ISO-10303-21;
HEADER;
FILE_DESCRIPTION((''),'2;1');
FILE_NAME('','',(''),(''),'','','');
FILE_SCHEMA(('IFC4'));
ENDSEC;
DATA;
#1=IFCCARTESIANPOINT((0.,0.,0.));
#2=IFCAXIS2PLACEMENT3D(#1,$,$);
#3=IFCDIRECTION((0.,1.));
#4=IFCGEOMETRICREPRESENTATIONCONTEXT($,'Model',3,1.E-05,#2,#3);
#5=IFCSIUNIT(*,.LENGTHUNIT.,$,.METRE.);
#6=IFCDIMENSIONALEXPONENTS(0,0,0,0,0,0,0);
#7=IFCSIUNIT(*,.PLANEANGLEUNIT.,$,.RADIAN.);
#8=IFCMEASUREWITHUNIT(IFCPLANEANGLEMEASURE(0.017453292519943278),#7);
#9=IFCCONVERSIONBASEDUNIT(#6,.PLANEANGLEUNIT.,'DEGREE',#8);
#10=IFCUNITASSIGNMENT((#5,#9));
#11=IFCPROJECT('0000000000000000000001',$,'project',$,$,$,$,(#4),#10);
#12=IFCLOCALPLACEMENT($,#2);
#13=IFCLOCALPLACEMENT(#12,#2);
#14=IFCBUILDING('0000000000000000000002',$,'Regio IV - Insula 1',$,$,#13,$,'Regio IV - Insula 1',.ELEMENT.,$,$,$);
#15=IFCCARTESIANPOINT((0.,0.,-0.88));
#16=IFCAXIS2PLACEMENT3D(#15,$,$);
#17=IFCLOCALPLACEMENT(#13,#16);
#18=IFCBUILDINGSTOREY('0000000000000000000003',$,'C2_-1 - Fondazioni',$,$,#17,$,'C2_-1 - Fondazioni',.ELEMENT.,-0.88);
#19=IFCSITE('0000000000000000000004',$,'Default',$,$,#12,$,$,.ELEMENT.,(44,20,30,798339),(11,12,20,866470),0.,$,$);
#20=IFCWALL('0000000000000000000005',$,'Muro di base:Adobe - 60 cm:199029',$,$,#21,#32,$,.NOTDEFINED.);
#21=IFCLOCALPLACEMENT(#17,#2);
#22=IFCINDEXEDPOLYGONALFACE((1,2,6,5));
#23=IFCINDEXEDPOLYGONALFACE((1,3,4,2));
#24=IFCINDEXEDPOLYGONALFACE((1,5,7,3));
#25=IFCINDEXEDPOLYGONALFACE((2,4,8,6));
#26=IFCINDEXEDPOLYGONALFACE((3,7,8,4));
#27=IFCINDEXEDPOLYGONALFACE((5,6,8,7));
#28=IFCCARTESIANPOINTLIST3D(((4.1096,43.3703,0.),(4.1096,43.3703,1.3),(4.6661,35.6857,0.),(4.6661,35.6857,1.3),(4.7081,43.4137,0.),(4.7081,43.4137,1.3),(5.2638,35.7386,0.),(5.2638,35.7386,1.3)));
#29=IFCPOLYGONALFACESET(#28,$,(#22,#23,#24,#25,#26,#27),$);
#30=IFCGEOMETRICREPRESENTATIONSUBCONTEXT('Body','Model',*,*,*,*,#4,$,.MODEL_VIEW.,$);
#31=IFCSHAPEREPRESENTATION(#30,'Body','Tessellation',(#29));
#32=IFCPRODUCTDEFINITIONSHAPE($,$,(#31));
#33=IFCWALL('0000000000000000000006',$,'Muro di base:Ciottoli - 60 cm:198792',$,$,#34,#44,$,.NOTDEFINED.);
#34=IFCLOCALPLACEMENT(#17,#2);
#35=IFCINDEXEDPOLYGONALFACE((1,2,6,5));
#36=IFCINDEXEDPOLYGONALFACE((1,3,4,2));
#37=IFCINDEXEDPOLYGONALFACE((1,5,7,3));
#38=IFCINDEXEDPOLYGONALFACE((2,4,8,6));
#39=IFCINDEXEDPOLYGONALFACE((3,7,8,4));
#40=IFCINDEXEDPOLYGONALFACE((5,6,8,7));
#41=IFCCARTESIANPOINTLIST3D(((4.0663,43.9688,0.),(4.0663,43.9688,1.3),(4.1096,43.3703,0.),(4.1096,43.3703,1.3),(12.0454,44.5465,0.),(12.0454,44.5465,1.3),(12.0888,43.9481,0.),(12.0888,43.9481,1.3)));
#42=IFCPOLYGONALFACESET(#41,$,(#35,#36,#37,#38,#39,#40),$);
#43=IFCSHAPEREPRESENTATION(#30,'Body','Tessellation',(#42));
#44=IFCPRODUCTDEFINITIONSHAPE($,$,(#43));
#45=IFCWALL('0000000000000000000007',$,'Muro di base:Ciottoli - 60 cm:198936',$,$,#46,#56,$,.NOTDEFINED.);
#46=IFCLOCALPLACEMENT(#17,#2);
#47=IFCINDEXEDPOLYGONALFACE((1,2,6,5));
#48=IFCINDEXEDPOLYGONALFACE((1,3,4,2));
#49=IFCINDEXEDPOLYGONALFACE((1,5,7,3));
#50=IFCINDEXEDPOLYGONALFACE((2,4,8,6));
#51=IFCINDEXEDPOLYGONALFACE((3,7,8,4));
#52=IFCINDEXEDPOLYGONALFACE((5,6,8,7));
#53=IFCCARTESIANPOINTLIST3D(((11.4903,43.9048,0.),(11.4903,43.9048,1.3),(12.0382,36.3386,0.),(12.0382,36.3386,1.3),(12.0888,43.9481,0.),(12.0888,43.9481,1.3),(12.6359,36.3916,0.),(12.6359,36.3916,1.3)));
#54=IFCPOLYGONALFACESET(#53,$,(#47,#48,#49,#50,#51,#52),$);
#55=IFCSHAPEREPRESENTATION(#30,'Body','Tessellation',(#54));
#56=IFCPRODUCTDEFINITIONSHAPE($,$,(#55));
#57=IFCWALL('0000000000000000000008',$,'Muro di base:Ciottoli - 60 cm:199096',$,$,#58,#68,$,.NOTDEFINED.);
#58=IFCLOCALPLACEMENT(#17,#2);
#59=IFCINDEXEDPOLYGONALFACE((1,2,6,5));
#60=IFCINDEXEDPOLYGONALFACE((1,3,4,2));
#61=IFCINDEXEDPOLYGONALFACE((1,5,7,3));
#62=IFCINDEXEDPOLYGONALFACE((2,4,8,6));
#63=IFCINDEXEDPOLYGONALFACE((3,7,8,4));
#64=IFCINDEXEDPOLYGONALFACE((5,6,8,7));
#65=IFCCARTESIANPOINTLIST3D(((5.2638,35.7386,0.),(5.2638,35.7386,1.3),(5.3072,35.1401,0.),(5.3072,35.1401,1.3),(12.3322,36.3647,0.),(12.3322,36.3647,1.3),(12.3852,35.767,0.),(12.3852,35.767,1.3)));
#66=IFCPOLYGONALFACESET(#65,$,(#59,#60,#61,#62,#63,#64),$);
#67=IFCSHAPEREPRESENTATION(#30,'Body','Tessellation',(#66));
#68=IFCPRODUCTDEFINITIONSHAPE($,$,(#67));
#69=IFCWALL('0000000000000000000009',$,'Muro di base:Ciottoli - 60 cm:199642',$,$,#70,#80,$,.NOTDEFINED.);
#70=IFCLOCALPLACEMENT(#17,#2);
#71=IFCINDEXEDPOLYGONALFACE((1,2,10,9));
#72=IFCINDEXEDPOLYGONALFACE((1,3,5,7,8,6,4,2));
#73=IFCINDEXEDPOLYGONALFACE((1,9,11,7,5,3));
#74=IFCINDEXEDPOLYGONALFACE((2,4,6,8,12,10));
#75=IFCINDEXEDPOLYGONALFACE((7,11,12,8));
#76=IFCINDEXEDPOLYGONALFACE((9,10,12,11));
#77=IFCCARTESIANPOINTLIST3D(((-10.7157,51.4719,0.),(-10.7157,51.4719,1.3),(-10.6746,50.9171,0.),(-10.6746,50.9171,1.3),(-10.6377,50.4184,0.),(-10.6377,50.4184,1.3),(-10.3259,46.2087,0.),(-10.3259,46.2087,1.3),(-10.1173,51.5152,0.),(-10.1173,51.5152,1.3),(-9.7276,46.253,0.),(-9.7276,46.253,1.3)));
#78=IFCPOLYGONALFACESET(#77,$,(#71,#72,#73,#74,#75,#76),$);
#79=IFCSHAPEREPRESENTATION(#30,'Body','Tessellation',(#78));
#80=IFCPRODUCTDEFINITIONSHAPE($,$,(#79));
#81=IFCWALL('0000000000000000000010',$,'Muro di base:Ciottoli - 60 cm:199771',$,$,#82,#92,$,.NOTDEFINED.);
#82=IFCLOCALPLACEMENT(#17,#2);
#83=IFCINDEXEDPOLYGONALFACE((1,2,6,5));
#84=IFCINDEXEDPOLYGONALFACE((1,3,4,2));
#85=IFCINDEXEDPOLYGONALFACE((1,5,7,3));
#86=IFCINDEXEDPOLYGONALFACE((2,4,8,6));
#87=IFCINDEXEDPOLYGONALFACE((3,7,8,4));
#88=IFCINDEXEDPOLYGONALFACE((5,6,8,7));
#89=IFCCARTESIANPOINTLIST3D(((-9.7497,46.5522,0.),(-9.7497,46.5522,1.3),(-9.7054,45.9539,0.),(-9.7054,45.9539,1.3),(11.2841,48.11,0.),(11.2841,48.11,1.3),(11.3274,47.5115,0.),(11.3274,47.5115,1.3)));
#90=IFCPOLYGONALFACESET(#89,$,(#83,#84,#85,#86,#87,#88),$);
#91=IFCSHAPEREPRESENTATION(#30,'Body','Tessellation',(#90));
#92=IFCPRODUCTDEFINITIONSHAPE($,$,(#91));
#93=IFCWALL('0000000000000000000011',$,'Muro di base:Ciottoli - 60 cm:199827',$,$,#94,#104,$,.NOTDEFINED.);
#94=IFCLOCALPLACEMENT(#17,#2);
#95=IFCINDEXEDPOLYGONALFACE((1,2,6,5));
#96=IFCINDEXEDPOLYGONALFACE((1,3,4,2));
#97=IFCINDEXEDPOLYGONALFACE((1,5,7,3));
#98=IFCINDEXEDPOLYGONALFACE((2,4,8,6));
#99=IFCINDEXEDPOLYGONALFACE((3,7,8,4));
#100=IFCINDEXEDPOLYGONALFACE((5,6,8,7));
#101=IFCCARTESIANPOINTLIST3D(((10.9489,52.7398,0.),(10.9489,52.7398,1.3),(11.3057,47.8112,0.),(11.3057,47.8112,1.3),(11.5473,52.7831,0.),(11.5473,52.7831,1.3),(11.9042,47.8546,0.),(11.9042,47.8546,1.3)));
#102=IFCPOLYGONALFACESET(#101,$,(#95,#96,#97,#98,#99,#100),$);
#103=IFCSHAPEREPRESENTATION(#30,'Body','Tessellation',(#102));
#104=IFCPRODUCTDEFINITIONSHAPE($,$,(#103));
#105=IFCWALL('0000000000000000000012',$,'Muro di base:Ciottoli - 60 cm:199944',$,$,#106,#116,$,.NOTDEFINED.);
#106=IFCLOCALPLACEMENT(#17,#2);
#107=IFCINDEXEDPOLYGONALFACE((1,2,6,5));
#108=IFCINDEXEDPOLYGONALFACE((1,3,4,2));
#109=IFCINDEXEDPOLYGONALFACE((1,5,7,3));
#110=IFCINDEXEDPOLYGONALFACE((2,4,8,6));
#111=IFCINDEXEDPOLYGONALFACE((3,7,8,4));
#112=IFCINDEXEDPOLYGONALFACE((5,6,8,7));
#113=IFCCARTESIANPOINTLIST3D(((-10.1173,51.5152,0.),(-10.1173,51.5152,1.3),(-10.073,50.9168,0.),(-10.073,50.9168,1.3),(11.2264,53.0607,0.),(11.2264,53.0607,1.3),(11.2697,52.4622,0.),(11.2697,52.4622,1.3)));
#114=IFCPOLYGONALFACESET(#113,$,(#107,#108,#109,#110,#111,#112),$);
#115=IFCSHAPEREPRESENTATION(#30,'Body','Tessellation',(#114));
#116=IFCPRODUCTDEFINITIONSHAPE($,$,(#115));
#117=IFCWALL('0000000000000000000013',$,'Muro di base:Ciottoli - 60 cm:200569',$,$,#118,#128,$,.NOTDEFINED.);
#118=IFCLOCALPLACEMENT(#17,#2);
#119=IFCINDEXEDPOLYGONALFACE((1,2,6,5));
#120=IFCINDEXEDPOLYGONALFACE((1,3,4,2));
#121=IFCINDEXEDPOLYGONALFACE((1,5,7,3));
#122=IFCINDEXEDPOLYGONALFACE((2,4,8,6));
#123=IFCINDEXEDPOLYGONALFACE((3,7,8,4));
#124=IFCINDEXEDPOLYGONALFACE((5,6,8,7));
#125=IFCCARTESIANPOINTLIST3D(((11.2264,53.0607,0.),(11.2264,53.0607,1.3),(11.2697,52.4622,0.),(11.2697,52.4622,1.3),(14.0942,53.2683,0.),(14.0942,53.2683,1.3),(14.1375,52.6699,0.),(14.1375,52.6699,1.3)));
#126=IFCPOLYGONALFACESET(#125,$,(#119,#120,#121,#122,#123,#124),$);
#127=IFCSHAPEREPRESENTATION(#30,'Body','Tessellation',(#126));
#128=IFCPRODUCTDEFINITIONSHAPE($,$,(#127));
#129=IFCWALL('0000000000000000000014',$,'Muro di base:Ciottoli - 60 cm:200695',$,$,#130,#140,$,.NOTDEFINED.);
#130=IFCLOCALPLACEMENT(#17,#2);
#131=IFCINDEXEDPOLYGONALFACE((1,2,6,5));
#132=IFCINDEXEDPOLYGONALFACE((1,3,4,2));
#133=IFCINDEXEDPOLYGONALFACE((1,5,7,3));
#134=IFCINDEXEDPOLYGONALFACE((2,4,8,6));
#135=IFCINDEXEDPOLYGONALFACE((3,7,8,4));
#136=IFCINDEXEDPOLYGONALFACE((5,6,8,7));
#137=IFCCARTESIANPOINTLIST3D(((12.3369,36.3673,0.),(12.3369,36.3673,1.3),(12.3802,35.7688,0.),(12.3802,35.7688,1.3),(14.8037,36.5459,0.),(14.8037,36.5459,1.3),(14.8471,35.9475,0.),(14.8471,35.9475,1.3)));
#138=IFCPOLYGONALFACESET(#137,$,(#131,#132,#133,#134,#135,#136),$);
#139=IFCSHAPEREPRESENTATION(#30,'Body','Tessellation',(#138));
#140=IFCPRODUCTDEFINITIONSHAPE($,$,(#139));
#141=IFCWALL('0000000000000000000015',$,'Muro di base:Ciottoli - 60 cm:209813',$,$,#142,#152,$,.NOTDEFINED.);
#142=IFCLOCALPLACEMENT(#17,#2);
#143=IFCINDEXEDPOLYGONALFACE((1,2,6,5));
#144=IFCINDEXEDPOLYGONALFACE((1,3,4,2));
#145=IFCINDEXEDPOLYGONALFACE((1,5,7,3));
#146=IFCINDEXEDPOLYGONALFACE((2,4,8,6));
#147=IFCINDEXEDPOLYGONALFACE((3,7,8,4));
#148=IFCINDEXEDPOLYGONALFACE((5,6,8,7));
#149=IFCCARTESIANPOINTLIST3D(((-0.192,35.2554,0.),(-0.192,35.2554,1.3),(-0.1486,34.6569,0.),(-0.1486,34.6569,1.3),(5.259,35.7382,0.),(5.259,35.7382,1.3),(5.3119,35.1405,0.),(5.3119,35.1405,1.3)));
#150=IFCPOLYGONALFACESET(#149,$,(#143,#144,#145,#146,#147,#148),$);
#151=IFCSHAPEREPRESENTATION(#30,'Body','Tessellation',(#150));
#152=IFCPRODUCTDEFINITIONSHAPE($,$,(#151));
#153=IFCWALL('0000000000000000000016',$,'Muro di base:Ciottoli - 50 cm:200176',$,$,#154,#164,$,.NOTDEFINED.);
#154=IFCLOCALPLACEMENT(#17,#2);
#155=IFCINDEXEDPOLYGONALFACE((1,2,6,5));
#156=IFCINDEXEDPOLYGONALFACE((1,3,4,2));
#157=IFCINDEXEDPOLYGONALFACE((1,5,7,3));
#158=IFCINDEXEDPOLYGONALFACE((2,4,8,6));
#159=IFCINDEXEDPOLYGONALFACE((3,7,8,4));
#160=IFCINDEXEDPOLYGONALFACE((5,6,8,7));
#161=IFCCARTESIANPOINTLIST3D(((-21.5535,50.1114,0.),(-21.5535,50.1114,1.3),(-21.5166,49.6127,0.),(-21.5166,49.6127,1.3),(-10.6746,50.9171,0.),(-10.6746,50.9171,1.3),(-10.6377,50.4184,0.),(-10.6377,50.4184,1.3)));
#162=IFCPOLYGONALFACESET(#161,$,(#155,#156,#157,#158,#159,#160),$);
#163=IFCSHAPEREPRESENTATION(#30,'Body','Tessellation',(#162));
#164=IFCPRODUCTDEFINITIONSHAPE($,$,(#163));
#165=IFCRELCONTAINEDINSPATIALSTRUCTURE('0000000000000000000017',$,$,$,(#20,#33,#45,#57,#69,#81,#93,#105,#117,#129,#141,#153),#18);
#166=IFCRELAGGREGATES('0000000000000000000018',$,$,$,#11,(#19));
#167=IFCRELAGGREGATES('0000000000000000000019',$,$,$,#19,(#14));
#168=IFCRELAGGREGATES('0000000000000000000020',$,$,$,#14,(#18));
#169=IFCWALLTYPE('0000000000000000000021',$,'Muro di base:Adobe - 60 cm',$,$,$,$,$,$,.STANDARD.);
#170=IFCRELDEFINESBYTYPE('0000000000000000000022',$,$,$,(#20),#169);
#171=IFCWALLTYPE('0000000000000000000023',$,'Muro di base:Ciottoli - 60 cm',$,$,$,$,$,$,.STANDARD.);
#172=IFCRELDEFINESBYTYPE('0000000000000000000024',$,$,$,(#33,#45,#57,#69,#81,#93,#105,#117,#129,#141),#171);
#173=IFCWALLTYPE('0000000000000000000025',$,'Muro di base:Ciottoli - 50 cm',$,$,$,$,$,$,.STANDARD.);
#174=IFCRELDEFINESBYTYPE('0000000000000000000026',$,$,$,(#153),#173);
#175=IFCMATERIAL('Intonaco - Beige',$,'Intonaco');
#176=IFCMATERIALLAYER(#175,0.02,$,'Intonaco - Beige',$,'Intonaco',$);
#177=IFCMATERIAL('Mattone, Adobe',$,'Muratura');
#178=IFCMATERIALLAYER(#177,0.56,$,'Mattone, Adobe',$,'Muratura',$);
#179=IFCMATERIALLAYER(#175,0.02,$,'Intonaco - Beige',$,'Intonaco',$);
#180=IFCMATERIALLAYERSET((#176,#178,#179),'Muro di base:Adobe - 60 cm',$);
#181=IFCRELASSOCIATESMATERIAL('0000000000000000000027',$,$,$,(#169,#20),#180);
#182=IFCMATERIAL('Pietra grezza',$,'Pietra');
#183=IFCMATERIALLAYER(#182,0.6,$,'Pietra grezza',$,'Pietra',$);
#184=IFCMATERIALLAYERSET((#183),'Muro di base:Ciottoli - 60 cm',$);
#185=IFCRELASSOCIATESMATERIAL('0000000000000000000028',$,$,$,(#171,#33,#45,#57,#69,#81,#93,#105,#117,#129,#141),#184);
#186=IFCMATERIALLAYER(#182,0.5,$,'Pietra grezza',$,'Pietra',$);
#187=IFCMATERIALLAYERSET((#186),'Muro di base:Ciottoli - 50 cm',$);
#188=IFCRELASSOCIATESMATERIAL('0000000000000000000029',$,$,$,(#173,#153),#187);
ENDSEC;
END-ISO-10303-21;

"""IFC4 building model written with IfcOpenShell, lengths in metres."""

from ifc_helpers import new_model, entity, si_unit, converted_unit, direction, frame, frame_2d, origin, place, context, subcontext, project, spatial, polyline, rectangle, outline, extrude, material, layer, layer_set, layer_usage, type_object, element, save


model = new_model("IFC4")

# Units and contexts
model_context = context("Model", 3, precision=1e-05, world=origin(), true_north=direction((0.0, 1.0)))
body_context = subcontext(model_context, "Body", "Model", "MODEL_VIEW")
ifc_project = project(units=[si_unit("LENGTHUNIT", "METRE"), converted_unit("PLANEANGLEUNIT", "DEGREE", entity("IfcPlaneAngleMeasure", 0.017453292519943278), si_unit("PLANEANGLEUNIT", "RADIAN"), dimensions=[0, 0, 0, 0, 0, 0, 0])], contexts=[model_context])

# Site, building, storey
site_placement = place(None, origin())
site = spatial("IfcSite", under=ifc_project, at=site_placement, Name="Default", CompositionType="ELEMENT", RefLatitude=(44, 20, 30, 798339), RefLongitude=(11, 12, 20, 866470), RefElevation=0.0)
building_placement = place(site_placement, origin())
building = spatial("IfcBuilding", under=site, at=building_placement, Name="Regio IV - Insula 1", LongName="Regio IV - Insula 1", CompositionType="ELEMENT")
storey_placement = place(building_placement, frame((0.0, 0.0, -0.88)))
storey = spatial("IfcBuildingStorey", under=building, at=storey_placement, Name="C2_-1 - Fondazioni", LongName="C2_-1 - Fondazioni", CompositionType="ELEMENT", Elevation=-0.88)

# Walls
ifc_material_1 = material(Name="Intonaco - Beige", Category="Intonaco")
ifc_layer_1 = layer(ifc_material_1, 0.02, Name="Intonaco - Beige", Category="Intonaco")
ifc_material_2 = material(Name="Mattone, Adobe", Category="Muratura")
ifc_layer_2 = layer(ifc_material_2, 0.56, Name="Mattone, Adobe", Category="Muratura")
ifc_layer_3 = layer(ifc_material_1, 0.02, Name="Intonaco - Beige", Category="Intonaco")
ifc_layer_set_1 = layer_set([ifc_layer_1, ifc_layer_2, ifc_layer_3], Name="Muro di base:Adobe - 60 cm")
ifc_layer_usage_1 = layer_usage(ifc_layer_set_1, "AXIS2", "NEGATIVE", 0.3)
wall_type_1 = type_object("IfcWallType", Name="Muro di base:Adobe - 60 cm", PredefinedType="STANDARD", material=ifc_layer_set_1)
wall_1_placement = place(storey_placement, frame((4.4089, 43.392, 0.0), z_axis=(0.0, 0.0, 1.0), x_axis=(0.07222, -0.997389, 0.0)))
element("IfcWall", 1, at=wall_1_placement, inside=storey, type_object=wall_type_1, material=ifc_layer_usage_1, Name="Muro di base:Adobe - 60 cm:199029", PredefinedType="NOTDEFINED", context=body_context, shape_type="SweptSolid", body=[
    extrude(outline(polyline([(7.7048, -0.3), (7.6951, 0.3), (0.0, 0.3), (0.0, -0.3), (7.7048, -0.3)])), origin(), (0.0, 0.0, 1.0), 1.3),
])
ifc_material_3 = material(Name="Pietra grezza", Category="Pietra")
ifc_layer_4 = layer(ifc_material_3, 0.6, Name="Pietra grezza", Category="Pietra")
ifc_layer_set_2 = layer_set([ifc_layer_4], Name="Muro di base:Ciottoli - 60 cm")
ifc_layer_usage_2 = layer_usage(ifc_layer_set_2, "AXIS2", "NEGATIVE", 0.3)
wall_type_2 = type_object("IfcWallType", Name="Muro di base:Ciottoli - 60 cm", PredefinedType="STANDARD", material=ifc_layer_set_2)
wall_2_placement = place(storey_placement, frame((4.088, 43.6695, 0.0), z_axis=(0.0, 0.0, 1.0), x_axis=(0.997389, 0.07222, 0.0)))
element("IfcWall", 2, at=wall_2_placement, inside=storey, type_object=wall_type_2, material=ifc_layer_usage_2, Name="Muro di base:Ciottoli - 60 cm:198792", PredefinedType="NOTDEFINED", context=body_context, shape_type="SweptSolid", body=[
    extrude(rectangle(XDim=8.0, YDim=0.6, at=frame_2d((4.0, 0.0), x_axis=(-1.0, 0.0))), origin(), (0.0, 0.0, 1.0), 1.3),
])
ifc_layer_usage_3 = layer_usage(ifc_layer_set_2, "AXIS2", "NEGATIVE", 0.3)
wall_3_placement = place(storey_placement, frame((11.7895, 43.9264, 0.0), z_axis=(0.0, 0.0, 1.0), x_axis=(0.07222, -0.997389, 0.0)))
element("IfcWall", 3, at=wall_3_placement, inside=storey, type_object=wall_type_2, material=ifc_layer_usage_3, Name="Muro di base:Ciottoli - 60 cm:198936", PredefinedType="NOTDEFINED", context=body_context, shape_type="SweptSolid", body=[
    extrude(outline(polyline([(7.5859, -0.3), (7.5763, 0.3), (0.0, 0.3), (0.0, -0.3), (7.5859, -0.3)])), origin(), (0.0, 0.0, 1.0), 1.3),
])
ifc_layer_usage_4 = layer_usage(ifc_layer_set_2, "AXIS2", "NEGATIVE", 0.3)
wall_4_placement = place(storey_placement, frame((5.2807, 35.4389, 0.0), z_axis=(0.0, 0.0, 1.0), x_axis=(0.996101, 0.088225, 0.0)))
element("IfcWall", 4, at=wall_4_placement, inside=storey, type_object=wall_type_2, material=ifc_layer_usage_4, Name="Muro di base:Ciottoli - 60 cm:199096", PredefinedType="NOTDEFINED", context=body_context, shape_type="SweptSolid", body=[
    extrude(outline(polyline([(7.1057, -0.3), (7.1057, 0.3), (0.0096, 0.3), (0.0, -0.3), (7.1057, -0.3)])), origin(), (0.0, 0.0, 1.0), 1.3),
])
ifc_layer_usage_5 = layer_usage(ifc_layer_set_2, "AXIS2", "NEGATIVE", 0.3)
wall_5_placement = place(storey_placement, frame((-10.4165, 51.494, 0.0), z_axis=(0.0, 0.0, 1.0), x_axis=(0.073857, -0.997269, 0.0)))
element("IfcWall", 5, at=wall_5_placement, inside=storey, type_object=wall_type_2, material=ifc_layer_usage_5, Name="Muro di base:Ciottoli - 60 cm:199642", PredefinedType="NOTDEFINED", context=body_context, shape_type="SweptSolid", body=[
    extrude(outline(polyline([(5.2776, -0.3), (5.2776, 0.3), (0.001, 0.3), (0.0, -0.3), (0.5563, -0.3), (1.0563, -0.3), (5.2776, -0.3)])), origin(), (0.0, 0.0, 1.0), 1.3),
])
ifc_layer_usage_6 = layer_usage(ifc_layer_set_2, "AXIS2", "NEGATIVE", 0.3)
wall_6_placement = place(storey_placement, frame((-9.7276, 46.253, 0.0), z_axis=(0.0, 0.0, 1.0), x_axis=(0.997269, 0.073857, 0.0)))
element("IfcWall", 6, at=wall_6_placement, inside=storey, type_object=wall_type_2, material=ifc_layer_usage_6, Name="Muro di base:Ciottoli - 60 cm:199771", PredefinedType="NOTDEFINED", context=body_context, shape_type="SweptSolid", body=[
    extrude(outline(polyline([(21.0905, -0.3), (21.0914, 0.3), (0.0, 0.3), (0.0, -0.3), (21.0905, -0.3)])), origin(), (0.0, 0.0, 1.0), 1.3),
])
ifc_layer_usage_7 = layer_usage(ifc_layer_set_2, "AXIS2", "NEGATIVE", 0.3)
wall_7_placement = place(storey_placement, frame((11.6049, 47.8329, 0.0), z_axis=(0.0, 0.0, 1.0), x_axis=(-0.07222, 0.997389, 0.0)))
element("IfcWall", 7, at=wall_7_placement, inside=storey, type_object=wall_type_2, material=ifc_layer_usage_7, Name="Muro di base:Ciottoli - 60 cm:199827", PredefinedType="NOTDEFINED", context=body_context, shape_type="SweptSolid", body=[
    extrude(rectangle(XDim=4.9415, YDim=0.6, at=frame_2d((2.4707, 0.0), x_axis=(-1.0, 0.0))), origin(), (0.0, 0.0, 1.0), 1.3),
])
ifc_layer_usage_8 = layer_usage(ifc_layer_set_2, "AXIS2", "NEGATIVE", 0.3)
wall_8_placement = place(storey_placement, frame((11.2481, 52.7615, 0.0), z_axis=(0.0, 0.0, 1.0), x_axis=(-0.997389, -0.07222, 0.0)))
element("IfcWall", 8, at=wall_8_placement, inside=storey, type_object=wall_type_2, material=ifc_layer_usage_8, Name="Muro di base:Ciottoli - 60 cm:199944", PredefinedType="NOTDEFINED", context=body_context, shape_type="SweptSolid", body=[
    extrude(outline(polyline([(21.3996, -0.3), (21.3986, 0.3), (0.0, 0.3), (0.0, -0.3), (21.3996, -0.3)])), origin(), (0.0, 0.0, 1.0), 1.3),
])
ifc_layer_usage_9 = layer_usage(ifc_layer_set_2, "AXIS2", "NEGATIVE", 0.3)
wall_9_placement = place(storey_placement, frame((11.2481, 52.7615, 0.0), z_axis=(0.0, 0.0, 1.0), x_axis=(0.997389, 0.07222, 0.0)))
element("IfcWall", 9, at=wall_9_placement, inside=storey, type_object=wall_type_2, material=ifc_layer_usage_9, Name="Muro di base:Ciottoli - 60 cm:200569", PredefinedType="NOTDEFINED", context=body_context, shape_type="SweptSolid", body=[
    extrude(rectangle(XDim=2.8753, YDim=0.6, at=frame_2d((1.4376, 0.0), x_axis=(-1.0, 0.0))), origin(), (0.0, 0.0, 1.0), 1.3),
])
ifc_layer_usage_10 = layer_usage(ifc_layer_set_2, "AXIS2", "NEGATIVE", 0.3)
wall_10_placement = place(storey_placement, frame((14.8254, 36.2467, 0.0), z_axis=(0.0, 0.0, 1.0), x_axis=(-0.997389, -0.07222, 0.0)))
element("IfcWall", 10, at=wall_10_placement, inside=storey, type_object=wall_type_2, material=ifc_layer_usage_10, Name="Muro di base:Ciottoli - 60 cm:200695", PredefinedType="NOTDEFINED", context=body_context, shape_type="SweptSolid", body=[
    extrude(rectangle(XDim=2.4733, YDim=0.6, at=frame_2d((1.2367, 0.0), x_axis=(-1.0, 0.0))), origin(), (0.0, 0.0, 1.0), 1.3),
])
ifc_layer_usage_11 = layer_usage(ifc_layer_set_2, "AXIS2", "NEGATIVE", 0.3)
wall_11_placement = place(storey_placement, frame((-0.1751, 34.9557, 0.0), z_axis=(0.0, 0.0, 1.0), x_axis=(0.996101, 0.088225, 0.0)))
element("IfcWall", 11, at=wall_11_placement, inside=storey, type_object=wall_type_2, material=ifc_layer_usage_11, Name="Muro di base:Ciottoli - 60 cm:209813", PredefinedType="NOTDEFINED", context=body_context, shape_type="SweptSolid", body=[
    extrude(outline(polyline([(5.4819, -0.3), (5.4819, 0.3), (0.0096, 0.3), (0.0, -0.3), (5.4819, -0.3)])), origin(), (0.0, 0.0, 1.0), 1.3),
])
ifc_layer_5 = layer(ifc_material_3, 0.5, Name="Pietra grezza", Category="Pietra")
ifc_layer_set_3 = layer_set([ifc_layer_5], Name="Muro di base:Ciottoli - 50 cm")
ifc_layer_usage_12 = layer_usage(ifc_layer_set_3, "AXIS2", "NEGATIVE", 0.25)
wall_type_3 = type_object("IfcWallType", Name="Muro di base:Ciottoli - 50 cm", PredefinedType="STANDARD", material=ifc_layer_set_3)
wall_12_placement = place(storey_placement, frame((-21.5351, 49.8621, 0.0), z_axis=(0.0, 0.0, 1.0), x_axis=(0.997269, 0.073857, 0.0)))
element("IfcWall", 12, at=wall_12_placement, inside=storey, type_object=wall_type_3, material=ifc_layer_usage_12, Name="Muro di base:Ciottoli - 50 cm:200176", PredefinedType="NOTDEFINED", context=body_context, shape_type="SweptSolid", body=[
    extrude(rectangle(XDim=10.9087, YDim=0.5, at=frame_2d((5.4543, 0.0), x_axis=(-1.0, 0.0))), origin(), (0.0, 0.0, 1.0), 1.3),
])

save(model, "model.ifc")
